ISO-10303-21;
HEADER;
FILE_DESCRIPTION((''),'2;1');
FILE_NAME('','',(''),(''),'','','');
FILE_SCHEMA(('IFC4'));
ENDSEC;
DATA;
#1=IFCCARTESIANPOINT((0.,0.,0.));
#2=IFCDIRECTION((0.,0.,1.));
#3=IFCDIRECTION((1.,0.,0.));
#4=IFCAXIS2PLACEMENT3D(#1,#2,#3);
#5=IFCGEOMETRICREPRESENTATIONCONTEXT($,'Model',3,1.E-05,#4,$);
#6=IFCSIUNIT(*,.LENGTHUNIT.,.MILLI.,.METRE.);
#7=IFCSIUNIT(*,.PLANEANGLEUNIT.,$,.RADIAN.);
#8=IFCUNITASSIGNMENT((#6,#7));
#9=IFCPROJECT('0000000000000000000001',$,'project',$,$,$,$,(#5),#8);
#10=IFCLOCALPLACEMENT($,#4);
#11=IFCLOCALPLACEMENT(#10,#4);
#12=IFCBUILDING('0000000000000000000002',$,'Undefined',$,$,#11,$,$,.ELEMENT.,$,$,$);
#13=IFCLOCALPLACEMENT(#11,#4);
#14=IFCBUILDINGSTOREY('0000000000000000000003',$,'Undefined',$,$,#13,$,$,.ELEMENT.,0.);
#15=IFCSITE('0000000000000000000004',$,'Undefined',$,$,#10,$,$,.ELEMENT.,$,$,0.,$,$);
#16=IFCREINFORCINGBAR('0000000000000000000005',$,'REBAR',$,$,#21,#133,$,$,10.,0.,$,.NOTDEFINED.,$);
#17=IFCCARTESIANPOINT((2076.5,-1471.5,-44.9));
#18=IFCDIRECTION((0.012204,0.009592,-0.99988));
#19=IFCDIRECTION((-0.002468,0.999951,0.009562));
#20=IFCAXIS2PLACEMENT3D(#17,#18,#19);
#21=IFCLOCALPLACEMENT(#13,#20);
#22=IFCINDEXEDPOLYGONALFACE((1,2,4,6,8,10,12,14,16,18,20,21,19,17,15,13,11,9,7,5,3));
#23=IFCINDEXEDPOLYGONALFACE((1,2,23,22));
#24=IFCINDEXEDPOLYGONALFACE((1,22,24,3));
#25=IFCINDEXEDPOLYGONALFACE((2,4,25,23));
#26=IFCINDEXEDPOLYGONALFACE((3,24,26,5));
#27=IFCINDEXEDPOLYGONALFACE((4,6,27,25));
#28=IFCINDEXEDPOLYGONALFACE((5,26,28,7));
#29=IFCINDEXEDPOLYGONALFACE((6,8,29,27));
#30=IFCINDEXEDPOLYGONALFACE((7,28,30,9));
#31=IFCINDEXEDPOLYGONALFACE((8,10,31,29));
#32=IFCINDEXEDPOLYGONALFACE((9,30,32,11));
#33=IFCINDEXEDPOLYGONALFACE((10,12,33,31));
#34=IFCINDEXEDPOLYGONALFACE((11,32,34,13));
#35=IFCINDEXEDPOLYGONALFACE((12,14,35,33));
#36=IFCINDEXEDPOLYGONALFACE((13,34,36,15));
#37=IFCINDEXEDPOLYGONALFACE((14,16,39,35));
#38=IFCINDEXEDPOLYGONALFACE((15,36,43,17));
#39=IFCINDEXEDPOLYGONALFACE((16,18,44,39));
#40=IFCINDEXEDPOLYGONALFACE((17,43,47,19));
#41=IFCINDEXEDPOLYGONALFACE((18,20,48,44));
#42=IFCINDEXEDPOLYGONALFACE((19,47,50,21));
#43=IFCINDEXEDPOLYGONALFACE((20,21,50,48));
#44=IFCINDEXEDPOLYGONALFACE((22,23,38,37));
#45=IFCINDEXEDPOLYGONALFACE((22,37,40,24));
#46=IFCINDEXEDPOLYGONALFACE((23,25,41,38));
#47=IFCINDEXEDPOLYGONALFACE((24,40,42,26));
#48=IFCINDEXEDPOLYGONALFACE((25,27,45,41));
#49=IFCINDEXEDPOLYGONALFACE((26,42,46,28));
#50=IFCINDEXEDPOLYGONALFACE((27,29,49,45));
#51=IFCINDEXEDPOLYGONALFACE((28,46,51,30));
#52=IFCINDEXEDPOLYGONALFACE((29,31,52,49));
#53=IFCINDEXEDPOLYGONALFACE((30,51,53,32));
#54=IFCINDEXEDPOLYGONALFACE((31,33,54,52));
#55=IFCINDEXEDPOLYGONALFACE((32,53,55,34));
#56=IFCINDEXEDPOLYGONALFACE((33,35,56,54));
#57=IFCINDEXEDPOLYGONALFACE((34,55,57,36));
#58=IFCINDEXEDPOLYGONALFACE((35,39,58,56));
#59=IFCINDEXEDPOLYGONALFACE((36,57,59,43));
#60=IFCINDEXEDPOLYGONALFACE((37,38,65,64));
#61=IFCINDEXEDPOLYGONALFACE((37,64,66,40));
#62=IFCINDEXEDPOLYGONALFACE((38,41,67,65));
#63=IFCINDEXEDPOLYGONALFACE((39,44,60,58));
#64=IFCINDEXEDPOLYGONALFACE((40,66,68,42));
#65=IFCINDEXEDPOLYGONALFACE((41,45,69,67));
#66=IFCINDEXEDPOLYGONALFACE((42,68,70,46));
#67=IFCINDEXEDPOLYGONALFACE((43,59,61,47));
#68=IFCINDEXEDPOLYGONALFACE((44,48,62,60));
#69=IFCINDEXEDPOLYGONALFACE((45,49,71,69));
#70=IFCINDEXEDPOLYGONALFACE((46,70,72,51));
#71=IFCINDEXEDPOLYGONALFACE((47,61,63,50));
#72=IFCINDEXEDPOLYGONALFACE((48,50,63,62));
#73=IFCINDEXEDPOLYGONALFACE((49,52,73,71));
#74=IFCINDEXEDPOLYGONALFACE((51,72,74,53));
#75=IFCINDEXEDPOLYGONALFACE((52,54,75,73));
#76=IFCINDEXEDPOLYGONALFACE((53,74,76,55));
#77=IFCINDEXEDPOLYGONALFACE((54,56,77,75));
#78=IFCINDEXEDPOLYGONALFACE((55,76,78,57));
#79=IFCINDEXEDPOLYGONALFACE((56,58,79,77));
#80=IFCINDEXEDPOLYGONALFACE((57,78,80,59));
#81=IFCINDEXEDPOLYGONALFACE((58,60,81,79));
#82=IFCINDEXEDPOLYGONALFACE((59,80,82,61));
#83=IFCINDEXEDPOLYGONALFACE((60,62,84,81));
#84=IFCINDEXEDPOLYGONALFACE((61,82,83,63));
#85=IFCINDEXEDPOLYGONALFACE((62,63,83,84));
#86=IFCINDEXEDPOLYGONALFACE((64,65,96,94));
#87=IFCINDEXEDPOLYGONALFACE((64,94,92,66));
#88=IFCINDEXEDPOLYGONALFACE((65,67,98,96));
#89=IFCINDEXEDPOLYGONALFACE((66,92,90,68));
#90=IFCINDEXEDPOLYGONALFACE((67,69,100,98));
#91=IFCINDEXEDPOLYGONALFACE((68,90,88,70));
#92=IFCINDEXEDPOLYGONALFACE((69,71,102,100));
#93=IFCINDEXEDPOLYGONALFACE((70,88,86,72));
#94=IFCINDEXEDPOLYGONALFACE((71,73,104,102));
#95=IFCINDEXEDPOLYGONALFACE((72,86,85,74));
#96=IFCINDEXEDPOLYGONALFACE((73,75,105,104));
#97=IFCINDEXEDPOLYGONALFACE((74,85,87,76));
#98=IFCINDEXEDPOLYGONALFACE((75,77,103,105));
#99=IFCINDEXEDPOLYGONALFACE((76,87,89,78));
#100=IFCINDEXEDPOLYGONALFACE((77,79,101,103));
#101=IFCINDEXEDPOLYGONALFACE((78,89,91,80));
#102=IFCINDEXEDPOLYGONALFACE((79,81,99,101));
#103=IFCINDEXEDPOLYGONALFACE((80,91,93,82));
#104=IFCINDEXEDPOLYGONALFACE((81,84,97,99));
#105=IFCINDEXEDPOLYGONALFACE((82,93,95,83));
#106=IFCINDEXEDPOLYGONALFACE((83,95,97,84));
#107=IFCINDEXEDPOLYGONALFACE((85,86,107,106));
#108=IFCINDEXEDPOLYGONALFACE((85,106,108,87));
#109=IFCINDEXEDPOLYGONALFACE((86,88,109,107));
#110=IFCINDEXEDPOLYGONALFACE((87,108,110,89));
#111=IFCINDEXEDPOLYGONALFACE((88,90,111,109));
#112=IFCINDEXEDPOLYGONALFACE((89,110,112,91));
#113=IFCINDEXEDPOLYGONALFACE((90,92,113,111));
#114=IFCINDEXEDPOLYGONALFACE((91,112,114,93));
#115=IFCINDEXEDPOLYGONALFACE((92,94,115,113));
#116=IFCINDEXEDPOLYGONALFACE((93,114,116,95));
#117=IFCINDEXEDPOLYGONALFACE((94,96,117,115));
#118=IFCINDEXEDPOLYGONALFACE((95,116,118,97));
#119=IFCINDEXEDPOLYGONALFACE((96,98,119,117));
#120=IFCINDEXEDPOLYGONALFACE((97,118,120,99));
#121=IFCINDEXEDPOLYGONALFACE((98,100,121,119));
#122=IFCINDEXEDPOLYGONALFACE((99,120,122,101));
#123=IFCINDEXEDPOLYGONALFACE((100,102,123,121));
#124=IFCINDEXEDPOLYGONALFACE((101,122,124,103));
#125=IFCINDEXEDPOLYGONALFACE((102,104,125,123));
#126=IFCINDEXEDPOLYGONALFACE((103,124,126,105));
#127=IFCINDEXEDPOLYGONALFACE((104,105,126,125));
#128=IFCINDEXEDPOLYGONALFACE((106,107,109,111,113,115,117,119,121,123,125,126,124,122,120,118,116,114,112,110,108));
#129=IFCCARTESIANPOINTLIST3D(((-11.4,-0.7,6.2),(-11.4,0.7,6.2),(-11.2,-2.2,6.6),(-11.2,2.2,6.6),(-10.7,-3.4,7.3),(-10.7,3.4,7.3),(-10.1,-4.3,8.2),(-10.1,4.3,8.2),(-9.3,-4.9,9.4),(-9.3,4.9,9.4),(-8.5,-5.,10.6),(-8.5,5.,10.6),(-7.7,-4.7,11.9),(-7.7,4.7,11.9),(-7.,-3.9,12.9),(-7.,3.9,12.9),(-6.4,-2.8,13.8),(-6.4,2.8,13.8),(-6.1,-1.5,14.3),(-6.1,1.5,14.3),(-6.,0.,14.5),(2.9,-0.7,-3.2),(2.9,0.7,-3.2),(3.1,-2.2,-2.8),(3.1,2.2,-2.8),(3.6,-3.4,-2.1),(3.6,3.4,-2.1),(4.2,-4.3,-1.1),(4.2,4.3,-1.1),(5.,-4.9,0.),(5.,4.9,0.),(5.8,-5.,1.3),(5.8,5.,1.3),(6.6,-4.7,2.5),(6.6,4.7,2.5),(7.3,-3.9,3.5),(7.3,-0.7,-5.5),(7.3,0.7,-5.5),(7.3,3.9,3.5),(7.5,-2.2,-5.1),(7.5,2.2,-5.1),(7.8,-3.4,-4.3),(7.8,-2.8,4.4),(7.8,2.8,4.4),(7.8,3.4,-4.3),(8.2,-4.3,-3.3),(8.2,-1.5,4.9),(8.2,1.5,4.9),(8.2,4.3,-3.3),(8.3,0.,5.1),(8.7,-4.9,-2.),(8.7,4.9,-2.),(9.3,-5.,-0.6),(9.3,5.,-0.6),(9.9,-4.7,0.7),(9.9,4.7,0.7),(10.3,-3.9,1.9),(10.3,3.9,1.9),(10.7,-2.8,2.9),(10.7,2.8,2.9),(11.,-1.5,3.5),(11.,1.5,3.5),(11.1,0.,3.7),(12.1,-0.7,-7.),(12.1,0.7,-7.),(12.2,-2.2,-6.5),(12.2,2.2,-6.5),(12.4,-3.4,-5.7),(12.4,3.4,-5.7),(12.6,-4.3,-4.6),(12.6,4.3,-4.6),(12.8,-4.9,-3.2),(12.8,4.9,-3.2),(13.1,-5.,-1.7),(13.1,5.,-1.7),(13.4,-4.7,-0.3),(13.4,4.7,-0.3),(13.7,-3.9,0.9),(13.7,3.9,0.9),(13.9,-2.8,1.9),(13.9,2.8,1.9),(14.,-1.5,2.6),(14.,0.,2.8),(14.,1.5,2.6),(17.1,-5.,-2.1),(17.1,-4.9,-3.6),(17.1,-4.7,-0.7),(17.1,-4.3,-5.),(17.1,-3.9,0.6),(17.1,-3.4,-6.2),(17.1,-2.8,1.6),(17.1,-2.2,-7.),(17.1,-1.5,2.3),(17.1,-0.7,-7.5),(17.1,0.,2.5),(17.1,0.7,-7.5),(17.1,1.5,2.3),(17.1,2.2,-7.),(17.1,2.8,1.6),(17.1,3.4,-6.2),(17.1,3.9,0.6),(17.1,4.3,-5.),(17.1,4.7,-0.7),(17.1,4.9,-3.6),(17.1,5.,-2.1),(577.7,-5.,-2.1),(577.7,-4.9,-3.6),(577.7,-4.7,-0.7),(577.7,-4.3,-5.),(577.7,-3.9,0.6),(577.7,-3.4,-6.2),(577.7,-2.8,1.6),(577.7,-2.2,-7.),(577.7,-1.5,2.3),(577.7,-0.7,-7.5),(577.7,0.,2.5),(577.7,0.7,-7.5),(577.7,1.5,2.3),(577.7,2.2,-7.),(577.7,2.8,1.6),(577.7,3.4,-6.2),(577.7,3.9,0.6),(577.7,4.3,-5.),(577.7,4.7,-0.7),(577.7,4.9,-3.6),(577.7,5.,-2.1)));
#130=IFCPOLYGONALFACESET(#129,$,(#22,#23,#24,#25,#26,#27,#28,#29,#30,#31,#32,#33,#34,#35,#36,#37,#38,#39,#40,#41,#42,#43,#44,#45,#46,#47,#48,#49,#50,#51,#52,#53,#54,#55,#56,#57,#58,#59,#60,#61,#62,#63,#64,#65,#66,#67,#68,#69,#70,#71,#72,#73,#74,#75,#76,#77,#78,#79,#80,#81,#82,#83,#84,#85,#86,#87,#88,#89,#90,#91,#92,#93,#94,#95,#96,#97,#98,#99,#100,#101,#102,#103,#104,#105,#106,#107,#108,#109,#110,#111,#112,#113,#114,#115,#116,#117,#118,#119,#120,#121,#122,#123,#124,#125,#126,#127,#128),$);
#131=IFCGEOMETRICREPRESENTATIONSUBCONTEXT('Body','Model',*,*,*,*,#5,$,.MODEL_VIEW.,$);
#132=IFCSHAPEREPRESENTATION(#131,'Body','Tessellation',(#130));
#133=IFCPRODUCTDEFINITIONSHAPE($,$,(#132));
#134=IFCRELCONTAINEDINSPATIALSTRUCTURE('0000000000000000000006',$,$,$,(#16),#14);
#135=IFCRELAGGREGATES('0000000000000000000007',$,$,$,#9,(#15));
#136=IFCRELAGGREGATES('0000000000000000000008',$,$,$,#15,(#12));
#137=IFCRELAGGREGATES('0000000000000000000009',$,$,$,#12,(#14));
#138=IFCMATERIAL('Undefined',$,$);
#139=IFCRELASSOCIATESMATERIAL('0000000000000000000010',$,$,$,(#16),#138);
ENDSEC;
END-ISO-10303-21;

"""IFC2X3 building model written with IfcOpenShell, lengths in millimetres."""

from ifc_helpers import new_model, entity, si_unit, frame, origin_with_axes, place, context, subcontext, project, spatial, source, transform, mapped, material, element, save


model = new_model("IFC2X3")

# Units and contexts
model_context = context("Model", 3, precision=1e-05, world=origin_with_axes())
body_context = subcontext(model_context, "Body", "Model", "MODEL_VIEW")
ifc_project = project(units=[si_unit("LENGTHUNIT", "METRE", prefix="MILLI"), si_unit("PLANEANGLEUNIT", "RADIAN")], contexts=[model_context])

# Site, building, storey
site_placement = place(None, origin_with_axes())
site = spatial("IfcSite", under=ifc_project, at=site_placement, Name="Undefined", CompositionType="ELEMENT", RefElevation=0.0)
building_placement = place(site_placement, origin_with_axes())
building = spatial("IfcBuilding", under=site, at=building_placement, Name="Undefined", CompositionType="ELEMENT")
storey_placement = place(building_placement, origin_with_axes())
storey = spatial("IfcBuildingStorey", under=building, at=storey_placement, Name="Undefined", CompositionType="ELEMENT", Elevation=0.0)

# Reinforcing bar
ifc_material_1 = material(Name="Undefined")
shared_shape_1 = source(origin_with_axes(), body_context, "Body", "AdvancedSweptSolid", [
    entity("IfcSweptDiskSolid", entity("IfcCompositeCurve", [entity("IfcCompositeCurveSegment", "CONTINUOUS", True, entity("IfcTrimmedCurve", entity("IfcLine", entity("IfcCartesianPoint", [0.0, 0.0, 0.0]), entity("IfcVector", entity("IfcDirection", [0.835483, 0.0, -0.549516]), 1.0)), [entity("IfcParameterValue", 0.0)], [entity("IfcParameterValue", 17.082101)], True, "PARAMETER")), entity("IfcCompositeCurveSegment", "CONTINUOUS", True, entity("IfcTrimmedCurve", entity("IfcCircle", entity("IfcAxis2Placement3D", entity("IfcCartesianPoint", [25.8, 0.0, 8.2]), entity("IfcDirection", [0.0, -1.0, 0.0]), entity("IfcDirection", [-0.549516, 0.0, -0.835483])), 21.0), [entity("IfcParameterValue", 0.0)], [entity("IfcParameterValue", 0.581785)], True, "PARAMETER")), entity("IfcCompositeCurveSegment", "DISCONTINUOUS", True, entity("IfcTrimmedCurve", entity("IfcLine", entity("IfcCartesianPoint", [25.8, 0.0, -12.8]), entity("IfcVector", entity("IfcDirection", [1.0, 0.0, 0.0]), 1.0)), [entity("IfcParameterValue", 0.0)], [entity("IfcParameterValue", 560.593055)], True, "PARAMETER"))], False), 5.0, None, 0.0, 578.3),
])
reinforcing_bar_1_placement = place(storey_placement, frame((2076.5, -1471.5, -44.9), z_axis=(0.012204, 0.009592, -0.99988), x_axis=(-0.002468, 0.999951, 0.009562)))
element("IfcReinforcingBar", 1, at=reinforcing_bar_1_placement, inside=storey, material=ifc_material_1, Name="REBAR", BarRole="NOTDEFINED", CrossSectionArea=0.0, NominalDiameter=10.0, context=body_context, shape_type="MappedRepresentation", body=[
    mapped(shared_shape_1, transform((-8.7, 0.0, 10.3))),
])

save(model, "model.ifc")
